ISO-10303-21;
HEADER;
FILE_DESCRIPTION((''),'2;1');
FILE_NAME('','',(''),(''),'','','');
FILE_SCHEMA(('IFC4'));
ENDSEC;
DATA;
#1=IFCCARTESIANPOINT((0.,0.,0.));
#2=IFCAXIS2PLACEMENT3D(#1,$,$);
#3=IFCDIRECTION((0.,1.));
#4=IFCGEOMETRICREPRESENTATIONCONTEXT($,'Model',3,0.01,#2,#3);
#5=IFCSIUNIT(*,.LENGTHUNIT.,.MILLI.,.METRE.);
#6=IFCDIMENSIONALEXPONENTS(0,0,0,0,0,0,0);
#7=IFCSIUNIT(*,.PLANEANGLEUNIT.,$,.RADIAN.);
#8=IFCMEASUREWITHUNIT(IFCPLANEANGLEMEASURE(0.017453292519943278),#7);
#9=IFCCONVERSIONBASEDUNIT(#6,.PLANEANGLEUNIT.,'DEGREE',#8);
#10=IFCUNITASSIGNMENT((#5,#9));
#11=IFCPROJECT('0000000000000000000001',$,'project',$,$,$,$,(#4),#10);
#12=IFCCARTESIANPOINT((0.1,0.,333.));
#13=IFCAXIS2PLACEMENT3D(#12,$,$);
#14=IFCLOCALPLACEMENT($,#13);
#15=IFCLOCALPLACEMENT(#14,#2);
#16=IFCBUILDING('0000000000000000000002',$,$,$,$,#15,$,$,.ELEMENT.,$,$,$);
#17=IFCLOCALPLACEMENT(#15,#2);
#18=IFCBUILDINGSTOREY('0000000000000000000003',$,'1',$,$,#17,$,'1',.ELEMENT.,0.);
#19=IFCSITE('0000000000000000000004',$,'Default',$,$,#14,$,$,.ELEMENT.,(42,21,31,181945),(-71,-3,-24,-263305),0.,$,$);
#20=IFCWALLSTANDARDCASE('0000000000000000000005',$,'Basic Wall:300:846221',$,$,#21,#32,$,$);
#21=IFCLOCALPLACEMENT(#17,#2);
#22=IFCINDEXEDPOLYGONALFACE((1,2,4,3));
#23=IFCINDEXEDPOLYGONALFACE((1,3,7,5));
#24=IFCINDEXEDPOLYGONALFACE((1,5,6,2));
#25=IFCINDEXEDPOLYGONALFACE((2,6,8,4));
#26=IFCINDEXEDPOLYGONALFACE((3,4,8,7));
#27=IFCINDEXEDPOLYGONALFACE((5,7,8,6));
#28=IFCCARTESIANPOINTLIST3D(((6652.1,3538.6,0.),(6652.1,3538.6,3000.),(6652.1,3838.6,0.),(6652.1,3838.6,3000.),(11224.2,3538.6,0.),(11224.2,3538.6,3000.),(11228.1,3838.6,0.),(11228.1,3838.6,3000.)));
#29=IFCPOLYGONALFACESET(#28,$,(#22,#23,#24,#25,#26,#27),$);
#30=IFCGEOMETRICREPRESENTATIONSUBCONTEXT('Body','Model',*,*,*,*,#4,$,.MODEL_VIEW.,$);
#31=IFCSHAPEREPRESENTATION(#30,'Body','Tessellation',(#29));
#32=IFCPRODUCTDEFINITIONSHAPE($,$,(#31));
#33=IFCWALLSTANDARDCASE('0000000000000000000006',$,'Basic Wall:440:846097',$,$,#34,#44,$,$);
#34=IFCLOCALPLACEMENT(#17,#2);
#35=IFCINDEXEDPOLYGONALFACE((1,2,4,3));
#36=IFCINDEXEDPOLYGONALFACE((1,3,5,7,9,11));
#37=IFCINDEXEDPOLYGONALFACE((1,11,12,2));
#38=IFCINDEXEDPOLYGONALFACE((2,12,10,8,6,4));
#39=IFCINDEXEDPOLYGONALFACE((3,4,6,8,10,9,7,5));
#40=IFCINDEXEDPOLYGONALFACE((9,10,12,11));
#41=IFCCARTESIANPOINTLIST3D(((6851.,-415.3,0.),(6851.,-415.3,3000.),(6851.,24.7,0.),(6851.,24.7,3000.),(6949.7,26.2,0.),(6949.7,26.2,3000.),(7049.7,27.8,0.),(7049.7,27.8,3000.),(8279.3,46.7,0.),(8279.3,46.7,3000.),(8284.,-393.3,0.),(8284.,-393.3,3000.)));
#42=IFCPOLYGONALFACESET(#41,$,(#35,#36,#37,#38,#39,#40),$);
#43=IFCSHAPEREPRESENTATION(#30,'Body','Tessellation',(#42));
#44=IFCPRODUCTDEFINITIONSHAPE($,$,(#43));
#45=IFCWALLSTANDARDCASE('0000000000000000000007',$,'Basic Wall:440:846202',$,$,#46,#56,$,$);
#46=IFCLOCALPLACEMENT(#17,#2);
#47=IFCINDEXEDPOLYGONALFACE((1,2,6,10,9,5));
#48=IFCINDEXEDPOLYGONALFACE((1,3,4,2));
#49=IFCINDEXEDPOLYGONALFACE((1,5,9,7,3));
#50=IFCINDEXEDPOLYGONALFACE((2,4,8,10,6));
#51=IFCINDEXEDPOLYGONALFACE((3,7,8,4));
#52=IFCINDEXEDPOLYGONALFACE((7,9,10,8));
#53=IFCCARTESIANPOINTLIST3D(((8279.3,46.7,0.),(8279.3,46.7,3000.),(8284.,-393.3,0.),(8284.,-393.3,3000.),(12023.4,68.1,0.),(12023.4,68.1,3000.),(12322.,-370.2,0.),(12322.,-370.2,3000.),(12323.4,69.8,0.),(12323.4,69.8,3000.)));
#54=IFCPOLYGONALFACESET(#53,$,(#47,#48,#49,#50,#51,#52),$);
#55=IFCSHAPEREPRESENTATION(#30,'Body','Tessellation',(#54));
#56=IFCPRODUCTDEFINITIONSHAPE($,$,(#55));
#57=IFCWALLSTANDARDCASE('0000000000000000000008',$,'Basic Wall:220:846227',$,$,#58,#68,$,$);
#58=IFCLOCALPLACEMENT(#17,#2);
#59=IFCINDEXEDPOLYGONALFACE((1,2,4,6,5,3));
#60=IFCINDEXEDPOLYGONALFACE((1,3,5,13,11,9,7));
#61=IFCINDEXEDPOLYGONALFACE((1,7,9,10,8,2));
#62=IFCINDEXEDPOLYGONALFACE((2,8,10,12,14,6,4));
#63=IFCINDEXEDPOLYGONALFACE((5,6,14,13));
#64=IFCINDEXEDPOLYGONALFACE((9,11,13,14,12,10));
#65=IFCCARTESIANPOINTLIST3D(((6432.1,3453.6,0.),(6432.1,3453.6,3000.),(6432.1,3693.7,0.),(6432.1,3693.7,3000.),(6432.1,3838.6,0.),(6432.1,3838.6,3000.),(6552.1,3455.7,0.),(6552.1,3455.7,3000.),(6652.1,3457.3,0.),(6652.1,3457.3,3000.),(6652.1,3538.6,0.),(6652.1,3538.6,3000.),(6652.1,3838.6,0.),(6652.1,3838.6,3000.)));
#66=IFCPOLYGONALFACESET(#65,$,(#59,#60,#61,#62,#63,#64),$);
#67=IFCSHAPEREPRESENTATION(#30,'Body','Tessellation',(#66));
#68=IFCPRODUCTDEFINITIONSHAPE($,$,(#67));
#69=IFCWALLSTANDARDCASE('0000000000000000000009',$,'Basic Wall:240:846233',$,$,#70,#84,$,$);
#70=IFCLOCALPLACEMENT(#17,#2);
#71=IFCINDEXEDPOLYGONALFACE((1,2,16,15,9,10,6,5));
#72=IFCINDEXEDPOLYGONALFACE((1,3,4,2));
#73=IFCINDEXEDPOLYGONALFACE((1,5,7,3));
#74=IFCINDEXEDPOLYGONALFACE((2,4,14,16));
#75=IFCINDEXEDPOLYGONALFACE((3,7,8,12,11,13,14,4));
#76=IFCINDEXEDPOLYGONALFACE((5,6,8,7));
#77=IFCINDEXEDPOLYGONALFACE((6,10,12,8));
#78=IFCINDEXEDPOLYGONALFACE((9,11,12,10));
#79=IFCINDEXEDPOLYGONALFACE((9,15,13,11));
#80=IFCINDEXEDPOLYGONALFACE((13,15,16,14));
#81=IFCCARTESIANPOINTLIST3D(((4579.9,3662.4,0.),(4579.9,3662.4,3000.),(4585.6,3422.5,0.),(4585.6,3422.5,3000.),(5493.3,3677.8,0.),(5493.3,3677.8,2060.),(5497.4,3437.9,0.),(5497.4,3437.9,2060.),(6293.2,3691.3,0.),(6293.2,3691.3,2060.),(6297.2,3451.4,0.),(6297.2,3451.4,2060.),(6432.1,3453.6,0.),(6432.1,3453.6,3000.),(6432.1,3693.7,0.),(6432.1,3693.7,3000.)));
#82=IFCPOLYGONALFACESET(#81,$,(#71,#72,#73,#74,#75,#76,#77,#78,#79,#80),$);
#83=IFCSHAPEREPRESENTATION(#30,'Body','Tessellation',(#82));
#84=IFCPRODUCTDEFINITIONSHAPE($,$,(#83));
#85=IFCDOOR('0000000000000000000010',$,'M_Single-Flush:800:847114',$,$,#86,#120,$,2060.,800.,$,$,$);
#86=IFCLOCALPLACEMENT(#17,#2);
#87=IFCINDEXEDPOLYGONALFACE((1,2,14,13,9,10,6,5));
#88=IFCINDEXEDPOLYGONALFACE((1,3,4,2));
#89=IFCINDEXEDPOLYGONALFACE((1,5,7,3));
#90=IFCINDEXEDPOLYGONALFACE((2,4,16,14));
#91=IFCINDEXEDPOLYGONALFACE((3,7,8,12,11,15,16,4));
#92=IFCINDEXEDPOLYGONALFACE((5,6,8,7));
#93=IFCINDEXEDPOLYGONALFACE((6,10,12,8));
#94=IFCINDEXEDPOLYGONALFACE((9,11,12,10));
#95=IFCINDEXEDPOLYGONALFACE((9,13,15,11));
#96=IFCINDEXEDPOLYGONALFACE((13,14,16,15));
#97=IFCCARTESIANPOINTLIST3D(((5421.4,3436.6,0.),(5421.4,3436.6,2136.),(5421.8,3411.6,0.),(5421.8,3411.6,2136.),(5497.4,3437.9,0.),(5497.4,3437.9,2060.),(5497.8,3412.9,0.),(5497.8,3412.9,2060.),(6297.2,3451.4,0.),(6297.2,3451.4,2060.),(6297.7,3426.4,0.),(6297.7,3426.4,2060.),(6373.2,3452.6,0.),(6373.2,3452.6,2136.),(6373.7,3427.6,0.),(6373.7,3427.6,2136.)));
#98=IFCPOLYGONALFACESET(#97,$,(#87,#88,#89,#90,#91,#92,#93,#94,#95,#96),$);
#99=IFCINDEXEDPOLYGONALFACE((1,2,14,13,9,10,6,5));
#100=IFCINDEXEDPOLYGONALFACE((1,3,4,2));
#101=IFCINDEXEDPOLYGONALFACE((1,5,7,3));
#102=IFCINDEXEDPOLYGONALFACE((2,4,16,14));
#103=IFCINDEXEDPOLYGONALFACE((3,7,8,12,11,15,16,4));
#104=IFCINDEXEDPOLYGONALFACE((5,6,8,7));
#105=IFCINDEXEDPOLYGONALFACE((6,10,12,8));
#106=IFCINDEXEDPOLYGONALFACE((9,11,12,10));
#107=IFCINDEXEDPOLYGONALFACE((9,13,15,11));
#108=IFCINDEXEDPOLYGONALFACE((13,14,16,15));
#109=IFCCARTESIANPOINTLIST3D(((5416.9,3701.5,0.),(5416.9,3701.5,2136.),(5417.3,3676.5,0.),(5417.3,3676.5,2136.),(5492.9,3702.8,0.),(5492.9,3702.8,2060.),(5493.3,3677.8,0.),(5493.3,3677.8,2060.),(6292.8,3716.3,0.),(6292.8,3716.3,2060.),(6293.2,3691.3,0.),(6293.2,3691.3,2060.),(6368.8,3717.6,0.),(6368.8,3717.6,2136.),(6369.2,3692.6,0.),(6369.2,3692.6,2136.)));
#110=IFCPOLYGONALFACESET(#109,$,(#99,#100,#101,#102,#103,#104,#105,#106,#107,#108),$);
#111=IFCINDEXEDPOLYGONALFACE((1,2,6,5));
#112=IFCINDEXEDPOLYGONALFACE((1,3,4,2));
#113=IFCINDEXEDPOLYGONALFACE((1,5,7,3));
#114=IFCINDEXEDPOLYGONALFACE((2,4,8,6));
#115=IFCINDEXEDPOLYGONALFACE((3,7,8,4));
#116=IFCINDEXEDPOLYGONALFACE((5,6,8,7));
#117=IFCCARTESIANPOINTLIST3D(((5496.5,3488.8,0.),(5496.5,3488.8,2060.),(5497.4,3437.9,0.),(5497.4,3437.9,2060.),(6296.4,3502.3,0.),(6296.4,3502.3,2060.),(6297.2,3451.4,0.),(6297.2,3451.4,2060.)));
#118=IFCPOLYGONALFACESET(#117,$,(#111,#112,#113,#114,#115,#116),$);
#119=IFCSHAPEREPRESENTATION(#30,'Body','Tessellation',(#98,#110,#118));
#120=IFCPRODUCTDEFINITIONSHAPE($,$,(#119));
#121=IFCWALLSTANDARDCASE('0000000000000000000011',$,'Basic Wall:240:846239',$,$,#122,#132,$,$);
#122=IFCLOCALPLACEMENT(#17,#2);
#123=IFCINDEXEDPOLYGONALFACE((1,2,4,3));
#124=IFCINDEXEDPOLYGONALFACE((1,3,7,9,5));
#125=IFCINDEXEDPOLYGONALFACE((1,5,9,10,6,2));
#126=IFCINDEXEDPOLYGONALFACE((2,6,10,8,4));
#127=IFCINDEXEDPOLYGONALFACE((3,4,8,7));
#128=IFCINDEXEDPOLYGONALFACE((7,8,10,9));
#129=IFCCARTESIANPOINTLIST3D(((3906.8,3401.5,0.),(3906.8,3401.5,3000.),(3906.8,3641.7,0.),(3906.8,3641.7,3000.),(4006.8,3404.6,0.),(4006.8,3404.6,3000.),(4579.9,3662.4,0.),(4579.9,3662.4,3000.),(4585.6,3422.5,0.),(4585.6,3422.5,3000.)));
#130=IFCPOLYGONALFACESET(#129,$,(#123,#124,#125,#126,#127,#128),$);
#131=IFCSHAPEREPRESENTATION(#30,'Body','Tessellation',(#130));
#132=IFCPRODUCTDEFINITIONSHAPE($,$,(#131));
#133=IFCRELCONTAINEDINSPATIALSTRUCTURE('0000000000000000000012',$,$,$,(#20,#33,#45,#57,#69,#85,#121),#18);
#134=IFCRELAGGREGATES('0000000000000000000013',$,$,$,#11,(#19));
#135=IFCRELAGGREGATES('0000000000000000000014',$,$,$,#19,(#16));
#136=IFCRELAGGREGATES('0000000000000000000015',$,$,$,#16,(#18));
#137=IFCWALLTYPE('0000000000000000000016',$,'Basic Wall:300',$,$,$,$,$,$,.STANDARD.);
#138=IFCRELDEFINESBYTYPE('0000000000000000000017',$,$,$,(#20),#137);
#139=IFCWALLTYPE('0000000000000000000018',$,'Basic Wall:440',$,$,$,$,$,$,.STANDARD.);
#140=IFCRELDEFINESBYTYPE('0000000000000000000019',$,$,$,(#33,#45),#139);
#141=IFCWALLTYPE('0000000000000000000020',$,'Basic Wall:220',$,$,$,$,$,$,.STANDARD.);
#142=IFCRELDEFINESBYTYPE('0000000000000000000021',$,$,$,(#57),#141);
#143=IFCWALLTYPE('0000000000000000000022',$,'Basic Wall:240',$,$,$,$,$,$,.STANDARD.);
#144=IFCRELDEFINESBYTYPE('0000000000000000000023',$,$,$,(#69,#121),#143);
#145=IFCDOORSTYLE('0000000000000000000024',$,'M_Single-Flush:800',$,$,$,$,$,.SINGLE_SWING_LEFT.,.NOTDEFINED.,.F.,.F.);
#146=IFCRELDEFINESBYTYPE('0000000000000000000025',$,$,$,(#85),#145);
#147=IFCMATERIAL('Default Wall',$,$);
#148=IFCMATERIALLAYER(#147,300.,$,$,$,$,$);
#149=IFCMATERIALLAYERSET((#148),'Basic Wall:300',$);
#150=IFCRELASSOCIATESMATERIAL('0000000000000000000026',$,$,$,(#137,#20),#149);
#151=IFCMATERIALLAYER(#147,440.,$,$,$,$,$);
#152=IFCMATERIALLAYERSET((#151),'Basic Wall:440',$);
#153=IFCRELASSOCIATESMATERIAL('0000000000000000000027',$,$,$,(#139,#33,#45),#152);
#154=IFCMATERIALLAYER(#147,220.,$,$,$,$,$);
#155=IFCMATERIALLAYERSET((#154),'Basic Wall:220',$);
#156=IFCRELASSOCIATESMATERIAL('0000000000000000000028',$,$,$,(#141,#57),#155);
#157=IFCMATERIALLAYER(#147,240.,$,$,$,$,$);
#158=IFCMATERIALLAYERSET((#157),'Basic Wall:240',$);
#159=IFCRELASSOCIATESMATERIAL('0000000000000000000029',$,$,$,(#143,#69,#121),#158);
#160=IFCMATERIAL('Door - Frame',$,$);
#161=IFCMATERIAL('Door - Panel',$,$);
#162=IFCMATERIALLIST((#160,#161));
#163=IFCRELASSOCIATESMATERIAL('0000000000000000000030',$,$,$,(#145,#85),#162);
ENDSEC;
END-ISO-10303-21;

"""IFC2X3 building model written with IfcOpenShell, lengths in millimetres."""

from ifc_helpers import new_model, entity, si_unit, converted_unit, direction, frame, frame_2d, origin, place, context, subcontext, project, spatial, polyline, rectangle, outline, extrude, source, transform, mapped, material, material_list, layer, layer_set, layer_usage, type_object, type_shapes, element, fill, save


model = new_model("IFC2X3")

# Units and contexts
model_context = context("Model", 3, precision=0.01, world=origin(), true_north=direction((0.0, 1.0)))
body_context = subcontext(model_context, "Body", "Model", "MODEL_VIEW")
ifc_project = project(units=[si_unit("LENGTHUNIT", "METRE", prefix="MILLI"), converted_unit("PLANEANGLEUNIT", "DEGREE", entity("IfcPlaneAngleMeasure", 0.017453292519943278), si_unit("PLANEANGLEUNIT", "RADIAN"), dimensions=[0, 0, 0, 0, 0, 0, 0])], contexts=[model_context])

# Site, building, storey
site_placement = place(None, frame((0.1, 0.0, 333.0)))
site = spatial("IfcSite", under=ifc_project, at=site_placement, Name="Default", CompositionType="ELEMENT", RefLatitude=(42, 21, 31, 181945), RefLongitude=(-71, -3, -24, -263305), RefElevation=0.0)
building_placement = place(site_placement, origin())
building = spatial("IfcBuilding", under=site, at=building_placement, CompositionType="ELEMENT")
storey_placement = place(building_placement, origin())
storey = spatial("IfcBuildingStorey", under=building, at=storey_placement, Name="1", LongName="1", CompositionType="ELEMENT", Elevation=0.0)

# Shared definitions
ifc_material_1 = material(Name="Default Wall")
ifc_layer_1 = layer(ifc_material_1, 300.0)
ifc_layer_set_1 = layer_set([ifc_layer_1], Name="Basic Wall:300")
wall_type_1 = type_object("IfcWallType", Name="Basic Wall:300", PredefinedType="STANDARD", material=ifc_layer_set_1)

# Walls
ifc_layer_usage_1 = layer_usage(ifc_layer_set_1, "AXIS2", "NEGATIVE", 150.0)
wall_1_placement = place(storey_placement, frame((6652.1, 3688.6, 0.0)))
element("IfcWallStandardCase", 1, at=wall_1_placement, inside=storey, type_object=wall_type_1, material=ifc_layer_usage_1, Name="Basic Wall:300:846221", context=body_context, shape_type="SweptSolid", body=[
    extrude(outline(polyline([(4572.1, -150.0), (4576.0, 150.0), (0.0, 150.0), (0.0, -150.0), (4572.1, -150.0)])), origin(), (0.0, 0.0, 1.0), 3000.0),
])
ifc_layer_2 = layer(ifc_material_1, 440.0)
ifc_layer_set_2 = layer_set([ifc_layer_2], Name="Basic Wall:440")
ifc_layer_usage_2 = layer_usage(ifc_layer_set_2, "AXIS2", "NEGATIVE", 220.0)
wall_type_2 = type_object("IfcWallType", Name="Basic Wall:440", PredefinedType="STANDARD", material=ifc_layer_set_2)
wall_2_placement = place(storey_placement, frame((8282.7, -173.2, 0.0), z_axis=(0.0, 0.0, 1.0), x_axis=(-0.999881, -0.015407, 0.0)))
element("IfcWallStandardCase", 2, at=wall_2_placement, inside=storey, type_object=wall_type_2, material=ifc_layer_usage_2, Name="Basic Wall:440:846097", context=body_context, shape_type="SweptSolid", body=[
    extrude(outline(polyline([(1428.5, -220.0), (1435.3, 220.0), (2.1, 220.0), (0.0, -220.0), (1229.8, -220.0), (1329.8, -220.0), (1428.5, -220.0)])), origin(), (0.0, 0.0, 1.0), 3000.0),
])
ifc_layer_usage_3 = layer_usage(ifc_layer_set_2, "AXIS2", "NEGATIVE", 220.0)
wall_3_placement = place(storey_placement, frame((12324.6, -150.2, 0.0), z_axis=(0.0, 0.0, 1.0), x_axis=(-0.999984, -0.005702, 0.0)))
element("IfcWallStandardCase", 3, at=wall_3_placement, inside=storey, type_object=wall_type_2, material=ifc_layer_usage_3, Name="Basic Wall:440:846202", context=body_context, shape_type="SweptSolid", body=[
    extrude(outline(polyline([(4044.1, -220.0), (4041.9, 220.0), (3.8, 220.0), (0.0, -220.0), (300.0, -220.0), (4044.1, -220.0)])), origin(), (0.0, 0.0, 1.0), 3000.0),
])
ifc_layer_3 = layer(ifc_material_1, 220.0)
ifc_layer_set_3 = layer_set([ifc_layer_3], Name="Basic Wall:220")
ifc_layer_usage_4 = layer_usage(ifc_layer_set_3, "AXIS2", "NEGATIVE", 110.0)
wall_type_3 = type_object("IfcWallType", Name="Basic Wall:220", PredefinedType="STANDARD", material=ifc_layer_set_3)
wall_4_placement = place(storey_placement, frame((6542.1, 3453.6, 0.0), z_axis=(0.0, 0.0, 1.0), x_axis=(0.0, 1.0, 0.0)))
element("IfcWallStandardCase", 4, at=wall_4_placement, inside=storey, type_object=wall_type_3, material=ifc_layer_usage_4, Name="Basic Wall:220:846227", context=body_context, shape_type="SweptSolid", body=[
    extrude(outline(polyline([(385.0, -110.0), (385.0, 110.0), (240.0, 110.0), (0.0, 110.0), (2.0, -10.0), (3.7, -110.0), (85.0, -110.0), (385.0, -110.0)])), origin(), (0.0, 0.0, 1.0), 3000.0),
])

# Wall, opening, door
ifc_layer_4 = layer(ifc_material_1, 240.0)
ifc_layer_set_4 = layer_set([ifc_layer_4], Name="Basic Wall:240")
ifc_layer_usage_5 = layer_usage(ifc_layer_set_4, "AXIS2", "NEGATIVE", 120.0)
wall_type_4 = type_object("IfcWallType", Name="Basic Wall:240", PredefinedType="STANDARD", material=ifc_layer_set_4)
wall_5_placement = place(storey_placement, frame((4581.9, 3542.4, 0.0), z_axis=(0.0, 0.0, 1.0), x_axis=(0.999858, 0.016875, 0.0)))
wall_5 = element("IfcWallStandardCase", 5, at=wall_5_placement, inside=storey, type_object=wall_type_4, material=ifc_layer_usage_5, Name="Basic Wall:240:846233", context=body_context, shape_type="SweptSolid", body=[
    extrude(outline(polyline([(1.7, -120.0), (214.1, -120.0), (314.2, -120.0), (1848.4, -120.0), (1852.5, 120.0), (0.0, 120.0), (1.7, -120.0)])), origin(), (0.0, 0.0, 1.0), 3000.0),
])
opening_1_placement = place(wall_5_placement, frame((1713.5, 120.0, 0.0)))
opening_1 = element("IfcOpeningElement", 6, at=opening_1_placement, cuts=wall_5, ObjectType="Opening", context=body_context, shape_type="SweptSolid", body=[
    extrude(rectangle(XDim=800.0, YDim=2060.0, at=frame_2d((1030.0, 400.0), x_axis=(0.0, -1.0))), frame((0.0, 0.0, 0.0), z_axis=(0.0, -1.0, 0.0), x_axis=(0.0, 0.0, 1.0)), (0.0, 0.0, 1.0), 240.0),
])
ifc_material_2 = material(Name="Door - Frame")
ifc_material_3 = material(Name="Door - Panel")
ifc_material_list_1 = material_list([ifc_material_2, ifc_material_3])
door_style_1 = type_object("IfcDoorStyle", Name="M_Single-Flush:800", ConstructionType="NOTDEFINED", OperationType="SINGLE_SWING_LEFT", ParameterTakesPrecedence=False, Sizeable=False, material=ifc_material_list_1)
shared_shape_1 = source(origin(), body_context, "Body", "SweptSolid", [
    extrude(outline(polyline([(-476.0, -1087.0), (476.0, -1087.0), (476.0, 1049.0), (400.0, 1049.0), (400.0, -1011.0), (-400.0, -1011.0), (-400.0, 1049.0), (-476.0, 1049.0), (-476.0, -1087.0)])), frame((400.0, 265.0, 1049.0), z_axis=(0.0, -1.0, 0.0), x_axis=(-1.0, 0.0, 0.0)), (0.0, 0.0, 1.0), 25.0),
    extrude(outline(polyline([(-1087.0, -476.0), (1049.0, -476.0), (1049.0, -400.0), (-1011.0, -400.0), (-1011.0, 400.0), (1049.0, 400.0), (1049.0, 476.0), (-1087.0, 476.0), (-1087.0, -476.0)])), frame((400.0, 0.0, 1049.0), z_axis=(0.0, -1.0, 0.0), x_axis=(0.0, 0.0, -1.0)), (0.0, 0.0, 1.0), 25.0),
    extrude(rectangle(XDim=800.0, YDim=51.0, at=frame_2d((0.0, 0.0), x_axis=(1.0, 0.0))), frame((400.0, 214.5, 0.0)), (0.0, 0.0, 1.0), 2060.0),
])
type_shapes(door_style_1, [shared_shape_1])
door_1_placement = place(opening_1_placement, frame((0.0, 0.0, 0.0), z_axis=(0.0, 0.0, 1.0), x_axis=(-1.0, 0.0, 0.0)))
door_1 = element("IfcDoor", 7, at=door_1_placement, inside=storey, type_object=door_style_1, material=ifc_material_list_1, Name="M_Single-Flush:800:847114", OverallHeight=2060.0, OverallWidth=800.0, context=body_context, shape_type="MappedRepresentation", body=[
    mapped(shared_shape_1, transform((0.0, 0.0, 0.0), scale=1.0)),
])
fill(opening_1, door_1)

# Wall
ifc_layer_usage_6 = layer_usage(ifc_layer_set_4, "AXIS2", "NEGATIVE", 120.0)
wall_6_placement = place(storey_placement, frame((3903.1, 3521.5, 0.0), z_axis=(0.0, 0.0, 1.0), x_axis=(0.999526, 0.030802, 0.0)))
element("IfcWallStandardCase", 8, at=wall_6_placement, inside=storey, type_object=wall_type_4, material=ifc_layer_usage_6, Name="Basic Wall:240:846239", context=body_context, shape_type="SweptSolid", body=[
    extrude(outline(polyline([(679.2, -120.0), (680.8, 120.0), (7.4, 120.0), (0.0, -120.0), (100.0, -120.0), (679.2, -120.0)])), origin(), (0.0, 0.0, 1.0), 3000.0),
])

save(model, "model.ifc")
